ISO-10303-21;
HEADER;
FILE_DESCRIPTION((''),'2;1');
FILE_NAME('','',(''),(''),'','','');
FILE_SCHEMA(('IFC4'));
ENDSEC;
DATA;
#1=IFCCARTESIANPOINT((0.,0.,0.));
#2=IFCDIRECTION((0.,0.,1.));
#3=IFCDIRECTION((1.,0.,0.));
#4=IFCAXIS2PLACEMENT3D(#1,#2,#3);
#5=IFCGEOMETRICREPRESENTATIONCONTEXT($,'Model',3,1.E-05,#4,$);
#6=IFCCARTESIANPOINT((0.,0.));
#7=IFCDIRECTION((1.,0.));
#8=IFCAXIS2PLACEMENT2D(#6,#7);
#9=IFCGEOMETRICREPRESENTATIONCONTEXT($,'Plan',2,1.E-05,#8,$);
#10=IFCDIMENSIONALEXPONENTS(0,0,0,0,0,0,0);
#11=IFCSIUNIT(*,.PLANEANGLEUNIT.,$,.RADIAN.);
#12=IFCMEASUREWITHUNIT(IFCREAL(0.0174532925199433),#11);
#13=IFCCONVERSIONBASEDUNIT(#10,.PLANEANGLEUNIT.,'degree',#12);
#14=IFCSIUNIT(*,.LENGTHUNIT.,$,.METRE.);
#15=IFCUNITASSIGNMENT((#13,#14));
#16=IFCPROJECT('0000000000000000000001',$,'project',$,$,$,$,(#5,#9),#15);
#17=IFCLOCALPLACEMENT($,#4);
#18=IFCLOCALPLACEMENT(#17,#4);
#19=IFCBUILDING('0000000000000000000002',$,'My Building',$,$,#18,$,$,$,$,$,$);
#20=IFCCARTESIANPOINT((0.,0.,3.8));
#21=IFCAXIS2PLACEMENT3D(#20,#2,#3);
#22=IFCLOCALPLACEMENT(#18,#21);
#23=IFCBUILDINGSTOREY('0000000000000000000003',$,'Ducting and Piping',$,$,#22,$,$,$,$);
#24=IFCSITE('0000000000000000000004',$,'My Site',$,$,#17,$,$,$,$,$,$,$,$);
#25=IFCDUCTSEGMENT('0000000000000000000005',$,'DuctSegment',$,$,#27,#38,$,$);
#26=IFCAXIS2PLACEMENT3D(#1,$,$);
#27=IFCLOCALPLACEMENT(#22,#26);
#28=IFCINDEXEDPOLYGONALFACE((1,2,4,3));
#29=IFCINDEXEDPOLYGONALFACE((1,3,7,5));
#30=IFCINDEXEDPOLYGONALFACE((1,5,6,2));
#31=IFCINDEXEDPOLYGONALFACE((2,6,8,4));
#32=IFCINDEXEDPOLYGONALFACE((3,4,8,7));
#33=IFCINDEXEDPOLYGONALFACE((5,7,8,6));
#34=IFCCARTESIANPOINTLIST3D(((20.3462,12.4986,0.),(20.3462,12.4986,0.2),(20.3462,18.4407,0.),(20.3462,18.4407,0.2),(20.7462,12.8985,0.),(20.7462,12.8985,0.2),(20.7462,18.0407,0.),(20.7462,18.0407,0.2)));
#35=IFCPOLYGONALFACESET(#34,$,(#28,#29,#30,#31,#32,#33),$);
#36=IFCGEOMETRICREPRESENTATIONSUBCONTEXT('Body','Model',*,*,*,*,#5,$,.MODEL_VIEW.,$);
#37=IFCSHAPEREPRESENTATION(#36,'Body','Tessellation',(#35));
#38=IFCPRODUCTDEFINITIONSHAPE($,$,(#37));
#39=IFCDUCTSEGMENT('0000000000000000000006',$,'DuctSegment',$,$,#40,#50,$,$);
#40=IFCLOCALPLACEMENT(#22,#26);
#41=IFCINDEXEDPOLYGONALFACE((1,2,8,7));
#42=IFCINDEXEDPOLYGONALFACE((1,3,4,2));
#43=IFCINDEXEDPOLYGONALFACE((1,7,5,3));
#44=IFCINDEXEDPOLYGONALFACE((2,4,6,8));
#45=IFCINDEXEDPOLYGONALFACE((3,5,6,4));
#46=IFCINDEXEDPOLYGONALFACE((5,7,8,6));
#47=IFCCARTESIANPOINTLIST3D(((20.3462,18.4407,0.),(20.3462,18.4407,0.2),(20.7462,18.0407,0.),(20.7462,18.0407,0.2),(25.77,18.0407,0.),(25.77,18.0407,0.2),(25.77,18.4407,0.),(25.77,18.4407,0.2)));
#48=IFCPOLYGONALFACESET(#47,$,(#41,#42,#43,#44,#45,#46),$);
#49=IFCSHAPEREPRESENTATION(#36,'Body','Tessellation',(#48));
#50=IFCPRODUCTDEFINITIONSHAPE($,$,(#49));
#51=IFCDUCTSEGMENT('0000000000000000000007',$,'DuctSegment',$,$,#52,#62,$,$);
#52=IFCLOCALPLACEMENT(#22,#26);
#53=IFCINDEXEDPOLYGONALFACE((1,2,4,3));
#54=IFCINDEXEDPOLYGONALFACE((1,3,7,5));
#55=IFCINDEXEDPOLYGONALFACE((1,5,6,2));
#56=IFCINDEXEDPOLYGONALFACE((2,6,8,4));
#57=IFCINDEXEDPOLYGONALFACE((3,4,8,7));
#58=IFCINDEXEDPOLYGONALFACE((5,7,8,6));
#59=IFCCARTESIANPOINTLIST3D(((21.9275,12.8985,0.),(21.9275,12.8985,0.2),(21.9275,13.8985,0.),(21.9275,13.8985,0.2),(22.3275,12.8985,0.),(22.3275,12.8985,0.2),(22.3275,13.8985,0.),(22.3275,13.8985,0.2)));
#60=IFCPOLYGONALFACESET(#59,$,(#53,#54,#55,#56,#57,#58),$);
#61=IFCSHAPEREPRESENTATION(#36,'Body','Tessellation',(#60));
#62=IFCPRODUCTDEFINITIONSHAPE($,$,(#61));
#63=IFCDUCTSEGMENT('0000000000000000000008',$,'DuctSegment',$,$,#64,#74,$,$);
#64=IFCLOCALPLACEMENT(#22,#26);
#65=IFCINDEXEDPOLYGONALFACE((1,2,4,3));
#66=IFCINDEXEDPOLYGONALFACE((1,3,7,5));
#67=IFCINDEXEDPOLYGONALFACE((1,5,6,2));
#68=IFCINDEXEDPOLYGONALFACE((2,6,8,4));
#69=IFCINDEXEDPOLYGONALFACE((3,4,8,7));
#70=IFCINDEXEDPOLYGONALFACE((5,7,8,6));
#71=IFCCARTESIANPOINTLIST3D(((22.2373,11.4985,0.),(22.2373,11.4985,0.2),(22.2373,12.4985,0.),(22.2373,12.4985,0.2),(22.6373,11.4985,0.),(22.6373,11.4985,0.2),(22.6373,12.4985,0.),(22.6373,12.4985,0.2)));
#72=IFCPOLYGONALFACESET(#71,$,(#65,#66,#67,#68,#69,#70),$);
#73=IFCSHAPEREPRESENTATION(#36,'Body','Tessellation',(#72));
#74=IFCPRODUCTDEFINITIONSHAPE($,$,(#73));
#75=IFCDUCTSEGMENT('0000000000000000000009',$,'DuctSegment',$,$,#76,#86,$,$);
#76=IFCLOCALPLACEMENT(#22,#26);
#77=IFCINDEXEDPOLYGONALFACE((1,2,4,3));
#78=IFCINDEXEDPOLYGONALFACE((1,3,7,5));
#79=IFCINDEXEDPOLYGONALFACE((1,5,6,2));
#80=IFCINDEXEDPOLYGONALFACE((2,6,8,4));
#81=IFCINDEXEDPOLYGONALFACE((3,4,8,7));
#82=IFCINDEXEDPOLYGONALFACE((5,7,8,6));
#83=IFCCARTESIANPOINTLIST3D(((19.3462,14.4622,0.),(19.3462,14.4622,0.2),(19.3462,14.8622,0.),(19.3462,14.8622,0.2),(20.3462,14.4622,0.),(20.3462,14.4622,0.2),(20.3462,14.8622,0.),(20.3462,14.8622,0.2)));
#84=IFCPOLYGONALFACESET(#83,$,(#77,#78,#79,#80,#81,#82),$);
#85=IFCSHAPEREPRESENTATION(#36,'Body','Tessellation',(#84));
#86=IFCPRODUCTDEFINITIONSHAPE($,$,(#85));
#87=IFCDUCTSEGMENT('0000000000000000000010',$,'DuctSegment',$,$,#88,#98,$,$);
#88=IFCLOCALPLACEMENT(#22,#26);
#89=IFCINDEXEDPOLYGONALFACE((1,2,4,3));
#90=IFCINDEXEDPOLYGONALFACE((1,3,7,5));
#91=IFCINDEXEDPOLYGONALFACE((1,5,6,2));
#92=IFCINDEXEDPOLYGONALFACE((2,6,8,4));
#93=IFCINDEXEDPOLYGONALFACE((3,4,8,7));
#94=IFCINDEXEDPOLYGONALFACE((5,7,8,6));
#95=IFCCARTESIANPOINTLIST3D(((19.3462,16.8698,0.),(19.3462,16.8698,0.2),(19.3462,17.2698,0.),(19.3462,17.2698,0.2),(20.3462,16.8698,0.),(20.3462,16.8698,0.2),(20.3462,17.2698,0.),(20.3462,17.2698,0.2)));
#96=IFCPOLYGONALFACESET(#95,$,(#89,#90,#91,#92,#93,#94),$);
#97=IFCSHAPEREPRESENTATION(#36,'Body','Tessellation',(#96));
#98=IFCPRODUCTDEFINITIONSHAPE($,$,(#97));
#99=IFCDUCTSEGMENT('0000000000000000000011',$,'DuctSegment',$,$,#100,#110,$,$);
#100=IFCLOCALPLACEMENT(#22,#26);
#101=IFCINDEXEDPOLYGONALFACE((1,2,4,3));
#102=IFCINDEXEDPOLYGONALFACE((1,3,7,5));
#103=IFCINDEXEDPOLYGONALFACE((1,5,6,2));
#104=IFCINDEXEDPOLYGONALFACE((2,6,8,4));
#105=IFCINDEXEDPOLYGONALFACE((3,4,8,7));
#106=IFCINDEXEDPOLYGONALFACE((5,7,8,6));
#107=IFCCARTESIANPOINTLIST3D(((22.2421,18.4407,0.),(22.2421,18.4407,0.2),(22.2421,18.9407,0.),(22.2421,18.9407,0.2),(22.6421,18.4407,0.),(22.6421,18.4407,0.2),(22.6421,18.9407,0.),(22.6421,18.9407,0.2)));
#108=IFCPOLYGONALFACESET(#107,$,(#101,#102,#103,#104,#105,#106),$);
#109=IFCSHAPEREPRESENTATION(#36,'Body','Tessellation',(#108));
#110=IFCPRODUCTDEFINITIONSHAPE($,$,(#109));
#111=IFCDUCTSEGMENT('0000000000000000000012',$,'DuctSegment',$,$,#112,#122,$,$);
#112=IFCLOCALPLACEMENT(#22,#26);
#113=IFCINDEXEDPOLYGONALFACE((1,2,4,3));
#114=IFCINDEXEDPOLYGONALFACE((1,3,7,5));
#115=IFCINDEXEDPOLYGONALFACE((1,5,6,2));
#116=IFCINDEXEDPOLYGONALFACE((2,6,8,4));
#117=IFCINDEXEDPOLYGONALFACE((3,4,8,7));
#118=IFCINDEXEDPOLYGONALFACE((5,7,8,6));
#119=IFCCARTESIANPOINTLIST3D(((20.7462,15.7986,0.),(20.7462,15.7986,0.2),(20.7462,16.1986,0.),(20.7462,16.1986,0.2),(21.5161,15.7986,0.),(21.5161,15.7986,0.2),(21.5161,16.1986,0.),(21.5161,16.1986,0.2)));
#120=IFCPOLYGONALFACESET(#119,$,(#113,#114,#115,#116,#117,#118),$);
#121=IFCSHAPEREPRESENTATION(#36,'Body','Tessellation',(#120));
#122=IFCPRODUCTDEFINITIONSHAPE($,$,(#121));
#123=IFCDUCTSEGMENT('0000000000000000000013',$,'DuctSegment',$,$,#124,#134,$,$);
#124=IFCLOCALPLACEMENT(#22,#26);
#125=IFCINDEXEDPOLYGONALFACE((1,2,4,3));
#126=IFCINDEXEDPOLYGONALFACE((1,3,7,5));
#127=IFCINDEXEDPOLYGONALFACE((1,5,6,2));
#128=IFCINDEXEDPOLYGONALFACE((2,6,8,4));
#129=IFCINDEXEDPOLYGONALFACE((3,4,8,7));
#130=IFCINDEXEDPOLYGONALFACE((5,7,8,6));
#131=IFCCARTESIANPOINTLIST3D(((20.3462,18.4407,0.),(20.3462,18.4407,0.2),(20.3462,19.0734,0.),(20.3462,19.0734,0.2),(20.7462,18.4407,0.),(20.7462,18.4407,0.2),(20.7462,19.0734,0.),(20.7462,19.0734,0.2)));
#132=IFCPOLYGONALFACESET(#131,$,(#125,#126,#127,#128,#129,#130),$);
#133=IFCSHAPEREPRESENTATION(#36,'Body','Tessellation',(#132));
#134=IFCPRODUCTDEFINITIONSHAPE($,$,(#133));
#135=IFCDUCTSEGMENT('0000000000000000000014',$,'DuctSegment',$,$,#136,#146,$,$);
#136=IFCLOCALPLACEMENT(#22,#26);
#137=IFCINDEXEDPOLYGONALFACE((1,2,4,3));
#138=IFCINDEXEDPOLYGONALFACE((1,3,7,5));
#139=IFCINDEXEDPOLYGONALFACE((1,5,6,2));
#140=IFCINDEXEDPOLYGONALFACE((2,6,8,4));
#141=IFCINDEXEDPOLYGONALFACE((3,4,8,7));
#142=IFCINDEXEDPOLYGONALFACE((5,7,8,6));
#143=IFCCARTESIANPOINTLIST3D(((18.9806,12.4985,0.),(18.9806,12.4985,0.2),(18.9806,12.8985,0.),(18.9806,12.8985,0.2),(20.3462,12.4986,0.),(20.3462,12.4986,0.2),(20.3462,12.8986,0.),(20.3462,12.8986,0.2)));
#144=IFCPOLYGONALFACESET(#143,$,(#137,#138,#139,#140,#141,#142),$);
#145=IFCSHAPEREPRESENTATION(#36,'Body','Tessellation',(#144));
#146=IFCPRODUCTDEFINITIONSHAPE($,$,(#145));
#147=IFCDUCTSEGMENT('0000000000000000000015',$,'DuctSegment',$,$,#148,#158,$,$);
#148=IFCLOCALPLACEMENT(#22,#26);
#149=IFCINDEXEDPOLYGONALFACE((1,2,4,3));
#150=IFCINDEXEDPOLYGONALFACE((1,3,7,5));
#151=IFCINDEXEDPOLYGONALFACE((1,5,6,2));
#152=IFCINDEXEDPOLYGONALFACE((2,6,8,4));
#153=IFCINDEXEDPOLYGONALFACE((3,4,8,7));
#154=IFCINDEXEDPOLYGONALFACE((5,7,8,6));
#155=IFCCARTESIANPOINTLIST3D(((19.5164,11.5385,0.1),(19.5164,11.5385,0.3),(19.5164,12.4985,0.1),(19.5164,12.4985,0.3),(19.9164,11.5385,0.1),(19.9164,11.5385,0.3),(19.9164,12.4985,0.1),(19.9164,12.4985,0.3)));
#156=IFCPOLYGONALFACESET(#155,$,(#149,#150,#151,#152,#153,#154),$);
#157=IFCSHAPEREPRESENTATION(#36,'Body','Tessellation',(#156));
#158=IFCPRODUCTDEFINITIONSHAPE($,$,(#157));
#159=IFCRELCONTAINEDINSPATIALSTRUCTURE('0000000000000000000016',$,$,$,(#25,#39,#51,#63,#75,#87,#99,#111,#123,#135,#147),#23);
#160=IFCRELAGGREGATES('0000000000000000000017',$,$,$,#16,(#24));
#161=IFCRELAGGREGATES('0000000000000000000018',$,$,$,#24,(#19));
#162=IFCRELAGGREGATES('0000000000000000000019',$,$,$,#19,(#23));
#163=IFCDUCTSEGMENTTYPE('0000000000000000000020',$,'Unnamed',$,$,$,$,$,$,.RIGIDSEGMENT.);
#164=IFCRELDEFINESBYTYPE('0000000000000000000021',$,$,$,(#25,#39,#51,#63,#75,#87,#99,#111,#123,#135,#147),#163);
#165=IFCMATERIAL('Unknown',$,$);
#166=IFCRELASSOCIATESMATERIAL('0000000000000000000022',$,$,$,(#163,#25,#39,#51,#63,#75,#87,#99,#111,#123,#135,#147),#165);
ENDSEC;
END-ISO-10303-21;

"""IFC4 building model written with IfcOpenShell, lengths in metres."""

from ifc_helpers import new_model, entity, si_unit, converted_unit, frame, origin_with_axes, origin_2d_with_axis, place, context, subcontext, project, spatial, rectangle, extrude, clip, halfspace, material, material_profile, profile_set, profile_usage, type_object, element, save


model = new_model("IFC4")

# Units and contexts
model_context = context("Model", 3, precision=1e-05, world=origin_with_axes())
plan_context = context("Plan", 2, precision=1e-05, world=origin_2d_with_axis())
body_context = subcontext(model_context, "Body", "Model", "MODEL_VIEW")
ifc_project = project(units=[converted_unit("PLANEANGLEUNIT", "degree", entity("IfcReal", 0.0174532925199433), si_unit("PLANEANGLEUNIT", "RADIAN"), dimensions=[0, 0, 0, 0, 0, 0, 0]), si_unit("LENGTHUNIT", "METRE")], contexts=[model_context, plan_context])

# Site, building, storey
site_placement = place(None, origin_with_axes())
site = spatial("IfcSite", under=ifc_project, at=site_placement, Name="My Site")
building_placement = place(site_placement, origin_with_axes())
building = spatial("IfcBuilding", under=site, at=building_placement, Name="My Building")
storey_placement = place(building_placement, frame((0.0, 0.0, 3.8), z_axis=(0.0, 0.0, 1.0), x_axis=(1.0, 0.0, 0.0)))
storey = spatial("IfcBuildingStorey", under=building, at=storey_placement, Name="Ducting and Piping")

# Shared definitions
ifc_material = material(Name="Unknown")

# Duct segments
ifc_material_profile_1 = material_profile(ifc_material, rectangle(XDim=0.4, YDim=0.2))
ifc_profile_set_1 = profile_set([ifc_material_profile_1])
ifc_profile_usage_1 = profile_usage(ifc_profile_set_1, cardinal=5)
duct_segment_type = type_object("IfcDuctSegmentType", Name="Unnamed", PredefinedType="RIGIDSEGMENT", material=ifc_profile_set_1)
duct_segment_1_placement = place(storey_placement, frame((20.5462, 12.4986, 0.1), z_axis=(0.0, 1.0, 0.0), x_axis=(-1.0, 0.0, 0.0)))
element("IfcDuctSegment", 1, at=duct_segment_1_placement, inside=storey, type_object=duct_segment_type, material=ifc_profile_usage_1, Name="DuctSegment", context=body_context, shape_type="Clipping", body=[
    clip(clip(extrude(rectangle(XDim=0.4, YDim=0.2), origin_with_axes(), (0.0, 0.0, 1.0), 5.9421), halfspace(frame((0.2, 0.0, 5.9421), z_axis=(-0.707107, 0.0, 0.707107), x_axis=(0.0, 1.0, 0.0)), False)), halfspace(frame((0.2, 0.0, 0.0), z_axis=(-0.707107, 0.0, -0.707107), x_axis=(0.0, 1.0, 0.0)), False)),
])
ifc_profile_usage_2 = profile_usage(ifc_profile_set_1, cardinal=5)
duct_segment_2_placement = place(storey_placement, frame((20.3462, 18.2407, 0.1), z_axis=(1.0, 0.0, 0.0), x_axis=(0.0, 1.0, 0.0)))
element("IfcDuctSegment", 2, at=duct_segment_2_placement, inside=storey, type_object=duct_segment_type, material=ifc_profile_usage_2, Name="DuctSegment", context=body_context, shape_type="Clipping", body=[
    clip(extrude(rectangle(XDim=0.4, YDim=0.2), origin_with_axes(), (0.0, 0.0, 1.0), 5.4238), halfspace(frame((0.2, 0.0, 0.0), z_axis=(-0.707107, 0.0, -0.707107), x_axis=(0.0, 1.0, 0.0)), False)),
])
ifc_profile_usage_3 = profile_usage(ifc_profile_set_1, cardinal=5)
duct_segment_3_placement = place(storey_placement, frame((22.1275, 12.8985, 0.1), z_axis=(0.0, 1.0, 0.0), x_axis=(-1.0, 0.0, 0.0)))
element("IfcDuctSegment", 3, at=duct_segment_3_placement, inside=storey, type_object=duct_segment_type, material=ifc_profile_usage_3, Name="DuctSegment", context=body_context, shape_type="SweptSolid", body=[
    extrude(rectangle(XDim=0.4, YDim=0.2), origin_with_axes(), (0.0, 0.0, 1.0), 1.0),
])
ifc_profile_usage_4 = profile_usage(ifc_profile_set_1, cardinal=5)
duct_segment_4_placement = place(storey_placement, frame((22.4373, 12.4985, 0.1), z_axis=(0.0, -1.0, 0.0), x_axis=(1.0, 0.0, 0.0)))
element("IfcDuctSegment", 4, at=duct_segment_4_placement, inside=storey, type_object=duct_segment_type, material=ifc_profile_usage_4, Name="DuctSegment", context=body_context, shape_type="SweptSolid", body=[
    extrude(rectangle(XDim=0.4, YDim=0.2), origin_with_axes(), (0.0, 0.0, 1.0), 1.0),
])
ifc_profile_usage_5 = profile_usage(ifc_profile_set_1, cardinal=5)
duct_segment_5_placement = place(storey_placement, frame((20.3462, 14.6622, 0.1), z_axis=(-1.0, 0.0, 0.0), x_axis=(0.0, -1.0, 0.0)))
element("IfcDuctSegment", 5, at=duct_segment_5_placement, inside=storey, type_object=duct_segment_type, material=ifc_profile_usage_5, Name="DuctSegment", context=body_context, shape_type="SweptSolid", body=[
    extrude(rectangle(XDim=0.4, YDim=0.2), origin_with_axes(), (0.0, 0.0, 1.0), 1.0),
])
ifc_profile_usage_6 = profile_usage(ifc_profile_set_1, cardinal=5)
duct_segment_6_placement = place(storey_placement, frame((20.3462, 17.0698, 0.1), z_axis=(-1.0, 0.0, 0.0), x_axis=(0.0, -1.0, 0.0)))
element("IfcDuctSegment", 6, at=duct_segment_6_placement, inside=storey, type_object=duct_segment_type, material=ifc_profile_usage_6, Name="DuctSegment", context=body_context, shape_type="SweptSolid", body=[
    extrude(rectangle(XDim=0.4, YDim=0.2), origin_with_axes(), (0.0, 0.0, 1.0), 1.0),
])
ifc_profile_usage_7 = profile_usage(ifc_profile_set_1, cardinal=5)
duct_segment_7_placement = place(storey_placement, frame((22.4421, 18.4407, 0.1), z_axis=(0.0, 1.0, 0.0), x_axis=(-1.0, 0.0, 0.0)))
element("IfcDuctSegment", 7, at=duct_segment_7_placement, inside=storey, type_object=duct_segment_type, material=ifc_profile_usage_7, Name="DuctSegment", context=body_context, shape_type="SweptSolid", body=[
    extrude(rectangle(XDim=0.4, YDim=0.2), origin_with_axes(), (0.0, 0.0, 1.0), 0.5),
])
ifc_profile_usage_8 = profile_usage(ifc_profile_set_1, cardinal=5)
duct_segment_8_placement = place(storey_placement, frame((20.7462, 15.9986, 0.1), z_axis=(1.0, 0.0, 0.0), x_axis=(0.0, 1.0, 0.0)))
element("IfcDuctSegment", 8, at=duct_segment_8_placement, inside=storey, type_object=duct_segment_type, material=ifc_profile_usage_8, Name="DuctSegment", context=body_context, shape_type="SweptSolid", body=[
    extrude(rectangle(XDim=0.4, YDim=0.2), origin_with_axes(), (0.0, 0.0, 1.0), 0.7698),
])
ifc_profile_usage_9 = profile_usage(ifc_profile_set_1, cardinal=5)
duct_segment_9_placement = place(storey_placement, frame((20.5462, 18.4407, 0.1), z_axis=(0.0, 1.0, 0.0), x_axis=(-1.0, 0.0, 0.0)))
element("IfcDuctSegment", 9, at=duct_segment_9_placement, inside=storey, type_object=duct_segment_type, material=ifc_profile_usage_9, Name="DuctSegment", context=body_context, shape_type="SweptSolid", body=[
    extrude(rectangle(XDim=0.4, YDim=0.2), origin_with_axes(), (0.0, 0.0, 1.0), 0.6328),
])
ifc_profile_usage_10 = profile_usage(ifc_profile_set_1, cardinal=5)
duct_segment_10_placement = place(storey_placement, frame((20.3462, 12.6986, 0.1), z_axis=(-1.0, -0.000001, 0.000001), x_axis=(0.000001, -1.0, 0.0)))
element("IfcDuctSegment", 10, at=duct_segment_10_placement, inside=storey, type_object=duct_segment_type, material=ifc_profile_usage_10, Name="DuctSegment", context=body_context, shape_type="SweptSolid", body=[
    extrude(rectangle(XDim=0.4, YDim=0.2), origin_with_axes(), (0.0, 0.0, 1.0), 1.3656),
])
ifc_profile_usage_11 = profile_usage(ifc_profile_set_1, cardinal=5)
duct_segment_11_placement = place(storey_placement, frame((19.7164, 12.4985, 0.2), z_axis=(0.0, -1.0, 0.0), x_axis=(1.0, 0.0, 0.0)))
element("IfcDuctSegment", 11, at=duct_segment_11_placement, inside=storey, type_object=duct_segment_type, material=ifc_profile_usage_11, Name="DuctSegment", context=body_context, shape_type="SweptSolid", body=[
    extrude(rectangle(XDim=0.4, YDim=0.2), origin_with_axes(), (0.0, 0.0, 1.0), 0.9601),
])

save(model, "model.ifc")
